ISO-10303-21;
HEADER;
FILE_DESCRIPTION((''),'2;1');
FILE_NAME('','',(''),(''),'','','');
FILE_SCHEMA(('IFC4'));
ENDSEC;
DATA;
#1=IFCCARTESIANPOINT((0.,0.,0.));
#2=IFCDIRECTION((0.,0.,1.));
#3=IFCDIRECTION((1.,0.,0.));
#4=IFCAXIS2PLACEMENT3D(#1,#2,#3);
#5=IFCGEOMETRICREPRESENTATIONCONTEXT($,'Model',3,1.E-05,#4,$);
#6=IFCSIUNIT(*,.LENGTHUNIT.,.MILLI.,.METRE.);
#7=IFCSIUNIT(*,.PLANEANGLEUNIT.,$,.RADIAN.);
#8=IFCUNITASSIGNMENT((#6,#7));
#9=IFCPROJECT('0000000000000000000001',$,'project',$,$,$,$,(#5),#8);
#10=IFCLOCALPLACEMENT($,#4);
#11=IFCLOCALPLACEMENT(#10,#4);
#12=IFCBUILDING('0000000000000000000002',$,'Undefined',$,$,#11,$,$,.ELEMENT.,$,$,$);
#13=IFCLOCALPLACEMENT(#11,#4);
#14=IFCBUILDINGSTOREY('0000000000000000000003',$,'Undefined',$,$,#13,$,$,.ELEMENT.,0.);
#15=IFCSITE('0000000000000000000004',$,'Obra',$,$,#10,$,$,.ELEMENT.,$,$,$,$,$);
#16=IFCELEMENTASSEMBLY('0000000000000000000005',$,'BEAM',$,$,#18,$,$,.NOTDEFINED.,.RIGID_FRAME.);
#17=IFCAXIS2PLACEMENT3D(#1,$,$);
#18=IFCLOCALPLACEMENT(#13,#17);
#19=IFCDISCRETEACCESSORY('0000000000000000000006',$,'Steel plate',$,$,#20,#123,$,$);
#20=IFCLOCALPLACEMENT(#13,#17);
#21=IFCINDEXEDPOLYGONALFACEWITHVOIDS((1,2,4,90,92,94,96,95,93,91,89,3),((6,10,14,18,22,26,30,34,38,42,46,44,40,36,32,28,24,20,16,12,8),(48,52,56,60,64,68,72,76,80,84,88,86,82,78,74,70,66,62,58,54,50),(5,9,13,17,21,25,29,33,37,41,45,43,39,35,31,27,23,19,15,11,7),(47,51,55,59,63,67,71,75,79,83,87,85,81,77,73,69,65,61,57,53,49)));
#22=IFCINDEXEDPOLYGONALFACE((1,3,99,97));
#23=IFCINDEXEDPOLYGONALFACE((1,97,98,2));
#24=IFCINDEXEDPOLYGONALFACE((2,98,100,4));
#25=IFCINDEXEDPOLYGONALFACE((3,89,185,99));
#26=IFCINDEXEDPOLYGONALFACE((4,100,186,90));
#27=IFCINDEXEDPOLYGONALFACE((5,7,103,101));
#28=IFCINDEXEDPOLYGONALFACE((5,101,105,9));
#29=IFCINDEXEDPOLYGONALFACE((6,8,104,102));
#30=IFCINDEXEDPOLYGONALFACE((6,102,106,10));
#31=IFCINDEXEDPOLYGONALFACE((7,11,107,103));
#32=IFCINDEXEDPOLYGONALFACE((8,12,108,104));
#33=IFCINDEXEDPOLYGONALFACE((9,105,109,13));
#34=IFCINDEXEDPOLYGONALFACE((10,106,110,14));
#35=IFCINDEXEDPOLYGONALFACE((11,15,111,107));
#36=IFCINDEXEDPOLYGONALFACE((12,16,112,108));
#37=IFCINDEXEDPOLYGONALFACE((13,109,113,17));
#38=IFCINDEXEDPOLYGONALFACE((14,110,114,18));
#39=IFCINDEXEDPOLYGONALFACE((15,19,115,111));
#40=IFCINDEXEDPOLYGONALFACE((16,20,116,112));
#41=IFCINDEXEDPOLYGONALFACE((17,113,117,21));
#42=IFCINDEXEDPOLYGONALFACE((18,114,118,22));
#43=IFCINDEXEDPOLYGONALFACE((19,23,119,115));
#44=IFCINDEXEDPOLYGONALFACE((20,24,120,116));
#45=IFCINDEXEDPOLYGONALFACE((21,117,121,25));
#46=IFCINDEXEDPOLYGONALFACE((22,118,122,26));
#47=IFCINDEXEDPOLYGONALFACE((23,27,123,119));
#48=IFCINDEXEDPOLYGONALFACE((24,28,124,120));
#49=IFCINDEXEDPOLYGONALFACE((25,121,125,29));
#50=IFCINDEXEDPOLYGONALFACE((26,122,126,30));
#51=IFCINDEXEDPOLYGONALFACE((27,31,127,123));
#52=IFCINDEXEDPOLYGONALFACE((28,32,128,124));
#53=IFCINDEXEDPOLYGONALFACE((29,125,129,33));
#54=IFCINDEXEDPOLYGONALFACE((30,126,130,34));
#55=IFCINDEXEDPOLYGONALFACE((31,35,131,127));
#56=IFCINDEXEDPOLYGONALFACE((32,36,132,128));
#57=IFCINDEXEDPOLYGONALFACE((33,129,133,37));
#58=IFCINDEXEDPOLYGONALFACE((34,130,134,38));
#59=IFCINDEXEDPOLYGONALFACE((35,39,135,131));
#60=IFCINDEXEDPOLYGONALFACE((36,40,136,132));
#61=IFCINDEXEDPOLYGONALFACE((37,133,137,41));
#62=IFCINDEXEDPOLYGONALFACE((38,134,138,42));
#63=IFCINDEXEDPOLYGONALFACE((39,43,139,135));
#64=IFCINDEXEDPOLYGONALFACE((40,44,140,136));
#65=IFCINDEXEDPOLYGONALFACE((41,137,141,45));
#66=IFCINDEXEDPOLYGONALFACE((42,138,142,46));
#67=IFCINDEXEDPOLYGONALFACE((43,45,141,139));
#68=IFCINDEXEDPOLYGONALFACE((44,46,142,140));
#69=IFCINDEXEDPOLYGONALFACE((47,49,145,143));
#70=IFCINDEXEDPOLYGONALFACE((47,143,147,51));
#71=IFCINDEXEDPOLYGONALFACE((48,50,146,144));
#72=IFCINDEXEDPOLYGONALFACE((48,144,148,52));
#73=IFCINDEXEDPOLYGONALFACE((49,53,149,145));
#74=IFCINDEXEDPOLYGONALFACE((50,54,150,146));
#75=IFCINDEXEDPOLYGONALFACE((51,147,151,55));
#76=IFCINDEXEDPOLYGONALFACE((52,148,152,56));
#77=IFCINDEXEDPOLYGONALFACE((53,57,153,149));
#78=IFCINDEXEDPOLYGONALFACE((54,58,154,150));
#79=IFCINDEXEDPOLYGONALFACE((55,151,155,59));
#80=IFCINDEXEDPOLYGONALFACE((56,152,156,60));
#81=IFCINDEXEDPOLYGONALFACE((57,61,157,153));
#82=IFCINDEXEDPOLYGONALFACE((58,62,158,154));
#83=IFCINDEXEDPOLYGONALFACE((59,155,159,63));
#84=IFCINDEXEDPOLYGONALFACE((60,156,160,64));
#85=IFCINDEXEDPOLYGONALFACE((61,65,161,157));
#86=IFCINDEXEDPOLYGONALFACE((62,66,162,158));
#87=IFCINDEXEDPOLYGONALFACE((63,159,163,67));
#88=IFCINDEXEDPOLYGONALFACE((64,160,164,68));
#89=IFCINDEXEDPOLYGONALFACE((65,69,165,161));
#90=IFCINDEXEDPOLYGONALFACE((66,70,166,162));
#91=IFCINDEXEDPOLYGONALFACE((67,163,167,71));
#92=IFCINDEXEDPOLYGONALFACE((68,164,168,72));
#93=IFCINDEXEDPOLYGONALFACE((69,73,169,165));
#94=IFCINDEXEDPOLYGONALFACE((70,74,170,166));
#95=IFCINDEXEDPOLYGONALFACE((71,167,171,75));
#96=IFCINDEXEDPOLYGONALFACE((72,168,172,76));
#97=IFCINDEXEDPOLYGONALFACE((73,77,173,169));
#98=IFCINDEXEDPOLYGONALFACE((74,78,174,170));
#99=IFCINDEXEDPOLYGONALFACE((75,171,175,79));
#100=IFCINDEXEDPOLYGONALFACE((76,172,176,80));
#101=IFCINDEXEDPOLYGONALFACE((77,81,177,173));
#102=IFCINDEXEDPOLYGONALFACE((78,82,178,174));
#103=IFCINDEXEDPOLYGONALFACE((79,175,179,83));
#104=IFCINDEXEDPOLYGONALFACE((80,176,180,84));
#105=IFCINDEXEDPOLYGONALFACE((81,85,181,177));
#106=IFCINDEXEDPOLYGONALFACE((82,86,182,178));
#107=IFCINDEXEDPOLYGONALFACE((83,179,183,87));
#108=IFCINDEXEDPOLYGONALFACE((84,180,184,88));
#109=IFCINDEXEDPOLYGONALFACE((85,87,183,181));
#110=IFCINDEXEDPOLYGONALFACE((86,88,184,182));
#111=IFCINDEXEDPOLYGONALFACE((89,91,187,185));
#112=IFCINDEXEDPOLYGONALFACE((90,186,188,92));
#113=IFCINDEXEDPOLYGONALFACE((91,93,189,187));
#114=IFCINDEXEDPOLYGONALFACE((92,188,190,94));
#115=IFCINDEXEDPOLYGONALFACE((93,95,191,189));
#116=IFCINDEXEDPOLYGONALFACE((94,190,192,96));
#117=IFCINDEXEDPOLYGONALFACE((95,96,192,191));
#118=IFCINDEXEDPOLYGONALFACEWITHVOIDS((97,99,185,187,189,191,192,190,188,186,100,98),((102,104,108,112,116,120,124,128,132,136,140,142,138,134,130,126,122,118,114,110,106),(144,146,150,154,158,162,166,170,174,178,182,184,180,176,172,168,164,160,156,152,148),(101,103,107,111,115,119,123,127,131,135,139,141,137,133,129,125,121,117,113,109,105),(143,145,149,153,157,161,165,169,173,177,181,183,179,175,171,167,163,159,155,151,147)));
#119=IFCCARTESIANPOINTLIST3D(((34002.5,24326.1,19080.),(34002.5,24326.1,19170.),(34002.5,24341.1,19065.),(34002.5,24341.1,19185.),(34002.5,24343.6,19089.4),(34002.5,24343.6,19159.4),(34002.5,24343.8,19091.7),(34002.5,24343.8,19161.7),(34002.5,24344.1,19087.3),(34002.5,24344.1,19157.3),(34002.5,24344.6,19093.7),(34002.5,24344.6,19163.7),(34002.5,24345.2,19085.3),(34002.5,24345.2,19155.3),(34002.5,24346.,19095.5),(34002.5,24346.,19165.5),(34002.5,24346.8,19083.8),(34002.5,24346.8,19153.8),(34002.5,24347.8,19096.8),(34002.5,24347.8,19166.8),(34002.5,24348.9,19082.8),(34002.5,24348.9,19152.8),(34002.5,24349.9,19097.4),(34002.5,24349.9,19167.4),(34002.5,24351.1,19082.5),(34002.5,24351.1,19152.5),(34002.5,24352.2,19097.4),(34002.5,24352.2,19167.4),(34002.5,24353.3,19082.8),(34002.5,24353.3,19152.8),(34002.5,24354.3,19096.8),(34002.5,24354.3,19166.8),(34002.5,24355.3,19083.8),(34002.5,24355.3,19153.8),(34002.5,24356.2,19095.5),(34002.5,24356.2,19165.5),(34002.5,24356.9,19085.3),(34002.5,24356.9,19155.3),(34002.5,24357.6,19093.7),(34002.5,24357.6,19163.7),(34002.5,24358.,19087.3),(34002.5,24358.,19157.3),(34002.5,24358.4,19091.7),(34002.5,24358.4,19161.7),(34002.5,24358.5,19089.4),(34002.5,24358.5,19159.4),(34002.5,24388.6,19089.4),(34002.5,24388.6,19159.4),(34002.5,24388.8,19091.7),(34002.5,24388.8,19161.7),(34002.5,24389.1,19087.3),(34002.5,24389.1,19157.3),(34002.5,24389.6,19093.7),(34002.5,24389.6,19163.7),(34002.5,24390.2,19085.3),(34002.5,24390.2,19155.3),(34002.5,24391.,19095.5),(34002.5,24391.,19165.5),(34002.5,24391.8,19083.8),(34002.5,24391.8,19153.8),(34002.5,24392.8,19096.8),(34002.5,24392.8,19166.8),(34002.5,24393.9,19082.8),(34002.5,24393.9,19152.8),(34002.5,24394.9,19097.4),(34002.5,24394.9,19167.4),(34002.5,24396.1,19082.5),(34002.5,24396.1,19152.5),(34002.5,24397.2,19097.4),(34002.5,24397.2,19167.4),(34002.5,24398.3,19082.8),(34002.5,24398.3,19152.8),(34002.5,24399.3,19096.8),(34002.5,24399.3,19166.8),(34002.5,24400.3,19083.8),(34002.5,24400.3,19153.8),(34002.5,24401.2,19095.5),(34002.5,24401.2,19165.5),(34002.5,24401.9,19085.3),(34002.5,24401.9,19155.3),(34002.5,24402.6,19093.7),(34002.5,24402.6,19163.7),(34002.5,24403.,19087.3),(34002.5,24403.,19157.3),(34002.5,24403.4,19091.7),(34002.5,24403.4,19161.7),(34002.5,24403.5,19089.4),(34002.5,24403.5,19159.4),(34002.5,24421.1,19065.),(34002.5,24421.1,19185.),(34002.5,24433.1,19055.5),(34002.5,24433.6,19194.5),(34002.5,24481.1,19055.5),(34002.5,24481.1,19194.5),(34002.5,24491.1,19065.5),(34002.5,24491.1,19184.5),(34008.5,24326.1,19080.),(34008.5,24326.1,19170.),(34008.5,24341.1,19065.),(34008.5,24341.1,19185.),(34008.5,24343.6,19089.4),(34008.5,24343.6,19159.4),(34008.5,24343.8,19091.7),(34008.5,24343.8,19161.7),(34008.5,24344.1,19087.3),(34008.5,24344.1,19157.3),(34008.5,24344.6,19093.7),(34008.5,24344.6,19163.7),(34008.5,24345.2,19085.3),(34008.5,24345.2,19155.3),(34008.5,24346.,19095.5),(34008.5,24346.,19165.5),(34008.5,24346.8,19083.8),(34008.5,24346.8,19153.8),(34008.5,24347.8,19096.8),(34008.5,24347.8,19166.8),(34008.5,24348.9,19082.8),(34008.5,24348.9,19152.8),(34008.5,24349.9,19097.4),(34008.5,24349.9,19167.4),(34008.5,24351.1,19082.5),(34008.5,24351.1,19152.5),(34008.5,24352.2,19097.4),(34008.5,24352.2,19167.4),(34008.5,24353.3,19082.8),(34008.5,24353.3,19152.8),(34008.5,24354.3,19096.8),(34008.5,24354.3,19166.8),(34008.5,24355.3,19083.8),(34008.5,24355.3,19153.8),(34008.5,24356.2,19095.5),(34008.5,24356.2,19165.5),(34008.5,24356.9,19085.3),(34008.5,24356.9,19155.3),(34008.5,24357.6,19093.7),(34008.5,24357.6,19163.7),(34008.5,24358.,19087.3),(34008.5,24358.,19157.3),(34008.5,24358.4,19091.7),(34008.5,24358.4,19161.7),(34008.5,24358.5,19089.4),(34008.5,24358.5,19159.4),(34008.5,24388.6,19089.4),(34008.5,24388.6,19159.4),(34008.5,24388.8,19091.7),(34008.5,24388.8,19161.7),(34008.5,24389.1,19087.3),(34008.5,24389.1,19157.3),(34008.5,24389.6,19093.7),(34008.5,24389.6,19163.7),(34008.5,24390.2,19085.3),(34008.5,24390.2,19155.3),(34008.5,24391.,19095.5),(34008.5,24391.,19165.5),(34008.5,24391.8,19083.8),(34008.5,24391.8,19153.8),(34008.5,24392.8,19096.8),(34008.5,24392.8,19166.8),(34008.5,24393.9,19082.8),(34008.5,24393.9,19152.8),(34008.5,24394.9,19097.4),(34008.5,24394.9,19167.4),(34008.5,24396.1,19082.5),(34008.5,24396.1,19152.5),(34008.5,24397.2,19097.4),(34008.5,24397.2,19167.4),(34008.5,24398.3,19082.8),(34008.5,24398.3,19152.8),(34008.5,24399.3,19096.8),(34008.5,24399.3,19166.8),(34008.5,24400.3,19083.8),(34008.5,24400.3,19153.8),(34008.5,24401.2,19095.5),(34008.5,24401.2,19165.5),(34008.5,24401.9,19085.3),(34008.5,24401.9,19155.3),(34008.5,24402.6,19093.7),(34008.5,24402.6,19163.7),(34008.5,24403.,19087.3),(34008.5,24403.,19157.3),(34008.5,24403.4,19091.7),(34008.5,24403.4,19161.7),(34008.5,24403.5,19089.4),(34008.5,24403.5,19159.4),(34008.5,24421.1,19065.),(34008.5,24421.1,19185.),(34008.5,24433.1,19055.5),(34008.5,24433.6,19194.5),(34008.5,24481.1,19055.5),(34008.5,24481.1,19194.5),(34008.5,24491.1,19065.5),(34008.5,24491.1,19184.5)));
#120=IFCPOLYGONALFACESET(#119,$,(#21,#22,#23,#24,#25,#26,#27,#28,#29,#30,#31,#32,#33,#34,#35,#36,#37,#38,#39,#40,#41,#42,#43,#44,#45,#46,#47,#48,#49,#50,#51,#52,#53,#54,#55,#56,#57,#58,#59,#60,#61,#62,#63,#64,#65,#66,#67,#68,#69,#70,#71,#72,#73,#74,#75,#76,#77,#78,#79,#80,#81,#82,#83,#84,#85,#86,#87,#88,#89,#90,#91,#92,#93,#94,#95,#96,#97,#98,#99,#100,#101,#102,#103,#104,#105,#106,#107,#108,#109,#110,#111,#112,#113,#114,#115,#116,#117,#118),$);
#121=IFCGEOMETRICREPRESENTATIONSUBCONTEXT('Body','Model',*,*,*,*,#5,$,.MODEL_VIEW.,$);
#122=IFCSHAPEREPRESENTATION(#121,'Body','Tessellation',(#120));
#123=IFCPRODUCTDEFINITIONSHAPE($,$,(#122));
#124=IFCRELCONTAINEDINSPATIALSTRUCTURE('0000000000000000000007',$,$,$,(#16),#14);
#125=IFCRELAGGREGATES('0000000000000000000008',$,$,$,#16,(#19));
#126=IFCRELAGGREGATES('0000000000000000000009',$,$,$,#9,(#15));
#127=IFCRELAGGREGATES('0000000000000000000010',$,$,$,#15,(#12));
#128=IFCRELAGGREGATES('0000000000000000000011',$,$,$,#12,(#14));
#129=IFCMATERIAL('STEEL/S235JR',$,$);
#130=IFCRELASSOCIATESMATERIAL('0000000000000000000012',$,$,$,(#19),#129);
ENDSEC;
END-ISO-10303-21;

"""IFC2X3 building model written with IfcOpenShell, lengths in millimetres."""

from ifc_helpers import new_model, si_unit, frame, origin_with_axes, origin_2d_with_axis, place, context, subcontext, project, spatial, polyline, circle, outline, extrude, source, transform, mapped, material, element, aggregate, save


model = new_model("IFC2X3")

# Units and contexts
model_context = context("Model", 3, precision=1e-05, world=origin_with_axes())
body_context = subcontext(model_context, "Body", "Model", "MODEL_VIEW")
ifc_project = project(units=[si_unit("LENGTHUNIT", "METRE", prefix="MILLI"), si_unit("PLANEANGLEUNIT", "RADIAN")], contexts=[model_context])

# Site, building, storey
site_placement = place(None, origin_with_axes())
site = spatial("IfcSite", under=ifc_project, at=site_placement, Name="Obra", CompositionType="ELEMENT")
building_placement = place(site_placement, origin_with_axes())
building = spatial("IfcBuilding", under=site, at=building_placement, Name="Undefined", CompositionType="ELEMENT")
storey_placement = place(building_placement, origin_with_axes())
storey = spatial("IfcBuildingStorey", under=building, at=storey_placement, Name="Undefined", CompositionType="ELEMENT", Elevation=0.0)

# Shared definitions
ifc_material_1 = material(Name="STEEL/S235JR")

# Element assembly, discrete accessory, opening
assembly_1_placement = place(storey_placement, origin_with_axes())
assembly_1 = element("IfcElementAssembly", 1, at=assembly_1_placement, inside=storey, Name="BEAM", AssemblyPlace="NOTDEFINED", PredefinedType="RIGID_FRAME")
discrete_accessory_1_placement = place(assembly_1_placement, frame((34005.5, 24491.1, 19065.5), z_axis=(-1.0, 0.0, 0.0), x_axis=(0.000001, -0.707107, -0.707107)))
discrete_accessory_1 = element("IfcDiscreteAccessory", 2, at=discrete_accessory_1_placement, material=ifc_material_1, Name="Steel plate", context=body_context, shape_type="SweptSolid", body=[
    extrude(outline(polyline([(0.0, 0.0), (14.1, 0.0), (48.1, 33.9), (49.9, 49.1), (106.4, 105.7), (106.4, 126.9), (42.8, 190.6), (21.6, 190.6), (-35.0, 134.0), (-50.6, 131.9), (-84.1, 98.3), (-84.1, 84.1), (0.0, 0.0)])), frame((0.0, 0.0, -3.0), z_axis=(0.0, 0.0, 1.0), x_axis=(1.0, 0.0, 0.0)), (0.0, 0.0, 1.0), 6.0),
])
shared_shape_1 = source(origin_with_axes(), body_context, "Body", "SweptSolid", [
    extrude(circle(Radius=7.5, at=origin_2d_with_axis()), frame((0.0, 2.4, 0.0), z_axis=(0.0, 1.0, 0.0), x_axis=(1.0, 0.0, 0.0)), (0.0, 0.0, 1.0), 6.2),
])
opening_1_placement = place(assembly_1_placement, frame((34000.0, 24373.6, 19160.0), z_axis=(0.0, -1.0, 0.0), x_axis=(0.0, 0.0, -1.0)))
element("IfcOpeningElement", 3, at=opening_1_placement, cuts=discrete_accessory_1, ObjectType="Opening", context=body_context, shape_type="MappedRepresentation", body=[
    mapped(shared_shape_1, transform((0.0, 0.0, -22.5))),
    mapped(shared_shape_1, transform((70.0, 0.0, -22.5))),
    mapped(shared_shape_1, transform((0.0, 0.0, 22.5))),
    mapped(shared_shape_1, transform((70.0, 0.0, 22.5))),
])

aggregate(assembly_1, [discrete_accessory_1])

save(model, "model.ifc")
